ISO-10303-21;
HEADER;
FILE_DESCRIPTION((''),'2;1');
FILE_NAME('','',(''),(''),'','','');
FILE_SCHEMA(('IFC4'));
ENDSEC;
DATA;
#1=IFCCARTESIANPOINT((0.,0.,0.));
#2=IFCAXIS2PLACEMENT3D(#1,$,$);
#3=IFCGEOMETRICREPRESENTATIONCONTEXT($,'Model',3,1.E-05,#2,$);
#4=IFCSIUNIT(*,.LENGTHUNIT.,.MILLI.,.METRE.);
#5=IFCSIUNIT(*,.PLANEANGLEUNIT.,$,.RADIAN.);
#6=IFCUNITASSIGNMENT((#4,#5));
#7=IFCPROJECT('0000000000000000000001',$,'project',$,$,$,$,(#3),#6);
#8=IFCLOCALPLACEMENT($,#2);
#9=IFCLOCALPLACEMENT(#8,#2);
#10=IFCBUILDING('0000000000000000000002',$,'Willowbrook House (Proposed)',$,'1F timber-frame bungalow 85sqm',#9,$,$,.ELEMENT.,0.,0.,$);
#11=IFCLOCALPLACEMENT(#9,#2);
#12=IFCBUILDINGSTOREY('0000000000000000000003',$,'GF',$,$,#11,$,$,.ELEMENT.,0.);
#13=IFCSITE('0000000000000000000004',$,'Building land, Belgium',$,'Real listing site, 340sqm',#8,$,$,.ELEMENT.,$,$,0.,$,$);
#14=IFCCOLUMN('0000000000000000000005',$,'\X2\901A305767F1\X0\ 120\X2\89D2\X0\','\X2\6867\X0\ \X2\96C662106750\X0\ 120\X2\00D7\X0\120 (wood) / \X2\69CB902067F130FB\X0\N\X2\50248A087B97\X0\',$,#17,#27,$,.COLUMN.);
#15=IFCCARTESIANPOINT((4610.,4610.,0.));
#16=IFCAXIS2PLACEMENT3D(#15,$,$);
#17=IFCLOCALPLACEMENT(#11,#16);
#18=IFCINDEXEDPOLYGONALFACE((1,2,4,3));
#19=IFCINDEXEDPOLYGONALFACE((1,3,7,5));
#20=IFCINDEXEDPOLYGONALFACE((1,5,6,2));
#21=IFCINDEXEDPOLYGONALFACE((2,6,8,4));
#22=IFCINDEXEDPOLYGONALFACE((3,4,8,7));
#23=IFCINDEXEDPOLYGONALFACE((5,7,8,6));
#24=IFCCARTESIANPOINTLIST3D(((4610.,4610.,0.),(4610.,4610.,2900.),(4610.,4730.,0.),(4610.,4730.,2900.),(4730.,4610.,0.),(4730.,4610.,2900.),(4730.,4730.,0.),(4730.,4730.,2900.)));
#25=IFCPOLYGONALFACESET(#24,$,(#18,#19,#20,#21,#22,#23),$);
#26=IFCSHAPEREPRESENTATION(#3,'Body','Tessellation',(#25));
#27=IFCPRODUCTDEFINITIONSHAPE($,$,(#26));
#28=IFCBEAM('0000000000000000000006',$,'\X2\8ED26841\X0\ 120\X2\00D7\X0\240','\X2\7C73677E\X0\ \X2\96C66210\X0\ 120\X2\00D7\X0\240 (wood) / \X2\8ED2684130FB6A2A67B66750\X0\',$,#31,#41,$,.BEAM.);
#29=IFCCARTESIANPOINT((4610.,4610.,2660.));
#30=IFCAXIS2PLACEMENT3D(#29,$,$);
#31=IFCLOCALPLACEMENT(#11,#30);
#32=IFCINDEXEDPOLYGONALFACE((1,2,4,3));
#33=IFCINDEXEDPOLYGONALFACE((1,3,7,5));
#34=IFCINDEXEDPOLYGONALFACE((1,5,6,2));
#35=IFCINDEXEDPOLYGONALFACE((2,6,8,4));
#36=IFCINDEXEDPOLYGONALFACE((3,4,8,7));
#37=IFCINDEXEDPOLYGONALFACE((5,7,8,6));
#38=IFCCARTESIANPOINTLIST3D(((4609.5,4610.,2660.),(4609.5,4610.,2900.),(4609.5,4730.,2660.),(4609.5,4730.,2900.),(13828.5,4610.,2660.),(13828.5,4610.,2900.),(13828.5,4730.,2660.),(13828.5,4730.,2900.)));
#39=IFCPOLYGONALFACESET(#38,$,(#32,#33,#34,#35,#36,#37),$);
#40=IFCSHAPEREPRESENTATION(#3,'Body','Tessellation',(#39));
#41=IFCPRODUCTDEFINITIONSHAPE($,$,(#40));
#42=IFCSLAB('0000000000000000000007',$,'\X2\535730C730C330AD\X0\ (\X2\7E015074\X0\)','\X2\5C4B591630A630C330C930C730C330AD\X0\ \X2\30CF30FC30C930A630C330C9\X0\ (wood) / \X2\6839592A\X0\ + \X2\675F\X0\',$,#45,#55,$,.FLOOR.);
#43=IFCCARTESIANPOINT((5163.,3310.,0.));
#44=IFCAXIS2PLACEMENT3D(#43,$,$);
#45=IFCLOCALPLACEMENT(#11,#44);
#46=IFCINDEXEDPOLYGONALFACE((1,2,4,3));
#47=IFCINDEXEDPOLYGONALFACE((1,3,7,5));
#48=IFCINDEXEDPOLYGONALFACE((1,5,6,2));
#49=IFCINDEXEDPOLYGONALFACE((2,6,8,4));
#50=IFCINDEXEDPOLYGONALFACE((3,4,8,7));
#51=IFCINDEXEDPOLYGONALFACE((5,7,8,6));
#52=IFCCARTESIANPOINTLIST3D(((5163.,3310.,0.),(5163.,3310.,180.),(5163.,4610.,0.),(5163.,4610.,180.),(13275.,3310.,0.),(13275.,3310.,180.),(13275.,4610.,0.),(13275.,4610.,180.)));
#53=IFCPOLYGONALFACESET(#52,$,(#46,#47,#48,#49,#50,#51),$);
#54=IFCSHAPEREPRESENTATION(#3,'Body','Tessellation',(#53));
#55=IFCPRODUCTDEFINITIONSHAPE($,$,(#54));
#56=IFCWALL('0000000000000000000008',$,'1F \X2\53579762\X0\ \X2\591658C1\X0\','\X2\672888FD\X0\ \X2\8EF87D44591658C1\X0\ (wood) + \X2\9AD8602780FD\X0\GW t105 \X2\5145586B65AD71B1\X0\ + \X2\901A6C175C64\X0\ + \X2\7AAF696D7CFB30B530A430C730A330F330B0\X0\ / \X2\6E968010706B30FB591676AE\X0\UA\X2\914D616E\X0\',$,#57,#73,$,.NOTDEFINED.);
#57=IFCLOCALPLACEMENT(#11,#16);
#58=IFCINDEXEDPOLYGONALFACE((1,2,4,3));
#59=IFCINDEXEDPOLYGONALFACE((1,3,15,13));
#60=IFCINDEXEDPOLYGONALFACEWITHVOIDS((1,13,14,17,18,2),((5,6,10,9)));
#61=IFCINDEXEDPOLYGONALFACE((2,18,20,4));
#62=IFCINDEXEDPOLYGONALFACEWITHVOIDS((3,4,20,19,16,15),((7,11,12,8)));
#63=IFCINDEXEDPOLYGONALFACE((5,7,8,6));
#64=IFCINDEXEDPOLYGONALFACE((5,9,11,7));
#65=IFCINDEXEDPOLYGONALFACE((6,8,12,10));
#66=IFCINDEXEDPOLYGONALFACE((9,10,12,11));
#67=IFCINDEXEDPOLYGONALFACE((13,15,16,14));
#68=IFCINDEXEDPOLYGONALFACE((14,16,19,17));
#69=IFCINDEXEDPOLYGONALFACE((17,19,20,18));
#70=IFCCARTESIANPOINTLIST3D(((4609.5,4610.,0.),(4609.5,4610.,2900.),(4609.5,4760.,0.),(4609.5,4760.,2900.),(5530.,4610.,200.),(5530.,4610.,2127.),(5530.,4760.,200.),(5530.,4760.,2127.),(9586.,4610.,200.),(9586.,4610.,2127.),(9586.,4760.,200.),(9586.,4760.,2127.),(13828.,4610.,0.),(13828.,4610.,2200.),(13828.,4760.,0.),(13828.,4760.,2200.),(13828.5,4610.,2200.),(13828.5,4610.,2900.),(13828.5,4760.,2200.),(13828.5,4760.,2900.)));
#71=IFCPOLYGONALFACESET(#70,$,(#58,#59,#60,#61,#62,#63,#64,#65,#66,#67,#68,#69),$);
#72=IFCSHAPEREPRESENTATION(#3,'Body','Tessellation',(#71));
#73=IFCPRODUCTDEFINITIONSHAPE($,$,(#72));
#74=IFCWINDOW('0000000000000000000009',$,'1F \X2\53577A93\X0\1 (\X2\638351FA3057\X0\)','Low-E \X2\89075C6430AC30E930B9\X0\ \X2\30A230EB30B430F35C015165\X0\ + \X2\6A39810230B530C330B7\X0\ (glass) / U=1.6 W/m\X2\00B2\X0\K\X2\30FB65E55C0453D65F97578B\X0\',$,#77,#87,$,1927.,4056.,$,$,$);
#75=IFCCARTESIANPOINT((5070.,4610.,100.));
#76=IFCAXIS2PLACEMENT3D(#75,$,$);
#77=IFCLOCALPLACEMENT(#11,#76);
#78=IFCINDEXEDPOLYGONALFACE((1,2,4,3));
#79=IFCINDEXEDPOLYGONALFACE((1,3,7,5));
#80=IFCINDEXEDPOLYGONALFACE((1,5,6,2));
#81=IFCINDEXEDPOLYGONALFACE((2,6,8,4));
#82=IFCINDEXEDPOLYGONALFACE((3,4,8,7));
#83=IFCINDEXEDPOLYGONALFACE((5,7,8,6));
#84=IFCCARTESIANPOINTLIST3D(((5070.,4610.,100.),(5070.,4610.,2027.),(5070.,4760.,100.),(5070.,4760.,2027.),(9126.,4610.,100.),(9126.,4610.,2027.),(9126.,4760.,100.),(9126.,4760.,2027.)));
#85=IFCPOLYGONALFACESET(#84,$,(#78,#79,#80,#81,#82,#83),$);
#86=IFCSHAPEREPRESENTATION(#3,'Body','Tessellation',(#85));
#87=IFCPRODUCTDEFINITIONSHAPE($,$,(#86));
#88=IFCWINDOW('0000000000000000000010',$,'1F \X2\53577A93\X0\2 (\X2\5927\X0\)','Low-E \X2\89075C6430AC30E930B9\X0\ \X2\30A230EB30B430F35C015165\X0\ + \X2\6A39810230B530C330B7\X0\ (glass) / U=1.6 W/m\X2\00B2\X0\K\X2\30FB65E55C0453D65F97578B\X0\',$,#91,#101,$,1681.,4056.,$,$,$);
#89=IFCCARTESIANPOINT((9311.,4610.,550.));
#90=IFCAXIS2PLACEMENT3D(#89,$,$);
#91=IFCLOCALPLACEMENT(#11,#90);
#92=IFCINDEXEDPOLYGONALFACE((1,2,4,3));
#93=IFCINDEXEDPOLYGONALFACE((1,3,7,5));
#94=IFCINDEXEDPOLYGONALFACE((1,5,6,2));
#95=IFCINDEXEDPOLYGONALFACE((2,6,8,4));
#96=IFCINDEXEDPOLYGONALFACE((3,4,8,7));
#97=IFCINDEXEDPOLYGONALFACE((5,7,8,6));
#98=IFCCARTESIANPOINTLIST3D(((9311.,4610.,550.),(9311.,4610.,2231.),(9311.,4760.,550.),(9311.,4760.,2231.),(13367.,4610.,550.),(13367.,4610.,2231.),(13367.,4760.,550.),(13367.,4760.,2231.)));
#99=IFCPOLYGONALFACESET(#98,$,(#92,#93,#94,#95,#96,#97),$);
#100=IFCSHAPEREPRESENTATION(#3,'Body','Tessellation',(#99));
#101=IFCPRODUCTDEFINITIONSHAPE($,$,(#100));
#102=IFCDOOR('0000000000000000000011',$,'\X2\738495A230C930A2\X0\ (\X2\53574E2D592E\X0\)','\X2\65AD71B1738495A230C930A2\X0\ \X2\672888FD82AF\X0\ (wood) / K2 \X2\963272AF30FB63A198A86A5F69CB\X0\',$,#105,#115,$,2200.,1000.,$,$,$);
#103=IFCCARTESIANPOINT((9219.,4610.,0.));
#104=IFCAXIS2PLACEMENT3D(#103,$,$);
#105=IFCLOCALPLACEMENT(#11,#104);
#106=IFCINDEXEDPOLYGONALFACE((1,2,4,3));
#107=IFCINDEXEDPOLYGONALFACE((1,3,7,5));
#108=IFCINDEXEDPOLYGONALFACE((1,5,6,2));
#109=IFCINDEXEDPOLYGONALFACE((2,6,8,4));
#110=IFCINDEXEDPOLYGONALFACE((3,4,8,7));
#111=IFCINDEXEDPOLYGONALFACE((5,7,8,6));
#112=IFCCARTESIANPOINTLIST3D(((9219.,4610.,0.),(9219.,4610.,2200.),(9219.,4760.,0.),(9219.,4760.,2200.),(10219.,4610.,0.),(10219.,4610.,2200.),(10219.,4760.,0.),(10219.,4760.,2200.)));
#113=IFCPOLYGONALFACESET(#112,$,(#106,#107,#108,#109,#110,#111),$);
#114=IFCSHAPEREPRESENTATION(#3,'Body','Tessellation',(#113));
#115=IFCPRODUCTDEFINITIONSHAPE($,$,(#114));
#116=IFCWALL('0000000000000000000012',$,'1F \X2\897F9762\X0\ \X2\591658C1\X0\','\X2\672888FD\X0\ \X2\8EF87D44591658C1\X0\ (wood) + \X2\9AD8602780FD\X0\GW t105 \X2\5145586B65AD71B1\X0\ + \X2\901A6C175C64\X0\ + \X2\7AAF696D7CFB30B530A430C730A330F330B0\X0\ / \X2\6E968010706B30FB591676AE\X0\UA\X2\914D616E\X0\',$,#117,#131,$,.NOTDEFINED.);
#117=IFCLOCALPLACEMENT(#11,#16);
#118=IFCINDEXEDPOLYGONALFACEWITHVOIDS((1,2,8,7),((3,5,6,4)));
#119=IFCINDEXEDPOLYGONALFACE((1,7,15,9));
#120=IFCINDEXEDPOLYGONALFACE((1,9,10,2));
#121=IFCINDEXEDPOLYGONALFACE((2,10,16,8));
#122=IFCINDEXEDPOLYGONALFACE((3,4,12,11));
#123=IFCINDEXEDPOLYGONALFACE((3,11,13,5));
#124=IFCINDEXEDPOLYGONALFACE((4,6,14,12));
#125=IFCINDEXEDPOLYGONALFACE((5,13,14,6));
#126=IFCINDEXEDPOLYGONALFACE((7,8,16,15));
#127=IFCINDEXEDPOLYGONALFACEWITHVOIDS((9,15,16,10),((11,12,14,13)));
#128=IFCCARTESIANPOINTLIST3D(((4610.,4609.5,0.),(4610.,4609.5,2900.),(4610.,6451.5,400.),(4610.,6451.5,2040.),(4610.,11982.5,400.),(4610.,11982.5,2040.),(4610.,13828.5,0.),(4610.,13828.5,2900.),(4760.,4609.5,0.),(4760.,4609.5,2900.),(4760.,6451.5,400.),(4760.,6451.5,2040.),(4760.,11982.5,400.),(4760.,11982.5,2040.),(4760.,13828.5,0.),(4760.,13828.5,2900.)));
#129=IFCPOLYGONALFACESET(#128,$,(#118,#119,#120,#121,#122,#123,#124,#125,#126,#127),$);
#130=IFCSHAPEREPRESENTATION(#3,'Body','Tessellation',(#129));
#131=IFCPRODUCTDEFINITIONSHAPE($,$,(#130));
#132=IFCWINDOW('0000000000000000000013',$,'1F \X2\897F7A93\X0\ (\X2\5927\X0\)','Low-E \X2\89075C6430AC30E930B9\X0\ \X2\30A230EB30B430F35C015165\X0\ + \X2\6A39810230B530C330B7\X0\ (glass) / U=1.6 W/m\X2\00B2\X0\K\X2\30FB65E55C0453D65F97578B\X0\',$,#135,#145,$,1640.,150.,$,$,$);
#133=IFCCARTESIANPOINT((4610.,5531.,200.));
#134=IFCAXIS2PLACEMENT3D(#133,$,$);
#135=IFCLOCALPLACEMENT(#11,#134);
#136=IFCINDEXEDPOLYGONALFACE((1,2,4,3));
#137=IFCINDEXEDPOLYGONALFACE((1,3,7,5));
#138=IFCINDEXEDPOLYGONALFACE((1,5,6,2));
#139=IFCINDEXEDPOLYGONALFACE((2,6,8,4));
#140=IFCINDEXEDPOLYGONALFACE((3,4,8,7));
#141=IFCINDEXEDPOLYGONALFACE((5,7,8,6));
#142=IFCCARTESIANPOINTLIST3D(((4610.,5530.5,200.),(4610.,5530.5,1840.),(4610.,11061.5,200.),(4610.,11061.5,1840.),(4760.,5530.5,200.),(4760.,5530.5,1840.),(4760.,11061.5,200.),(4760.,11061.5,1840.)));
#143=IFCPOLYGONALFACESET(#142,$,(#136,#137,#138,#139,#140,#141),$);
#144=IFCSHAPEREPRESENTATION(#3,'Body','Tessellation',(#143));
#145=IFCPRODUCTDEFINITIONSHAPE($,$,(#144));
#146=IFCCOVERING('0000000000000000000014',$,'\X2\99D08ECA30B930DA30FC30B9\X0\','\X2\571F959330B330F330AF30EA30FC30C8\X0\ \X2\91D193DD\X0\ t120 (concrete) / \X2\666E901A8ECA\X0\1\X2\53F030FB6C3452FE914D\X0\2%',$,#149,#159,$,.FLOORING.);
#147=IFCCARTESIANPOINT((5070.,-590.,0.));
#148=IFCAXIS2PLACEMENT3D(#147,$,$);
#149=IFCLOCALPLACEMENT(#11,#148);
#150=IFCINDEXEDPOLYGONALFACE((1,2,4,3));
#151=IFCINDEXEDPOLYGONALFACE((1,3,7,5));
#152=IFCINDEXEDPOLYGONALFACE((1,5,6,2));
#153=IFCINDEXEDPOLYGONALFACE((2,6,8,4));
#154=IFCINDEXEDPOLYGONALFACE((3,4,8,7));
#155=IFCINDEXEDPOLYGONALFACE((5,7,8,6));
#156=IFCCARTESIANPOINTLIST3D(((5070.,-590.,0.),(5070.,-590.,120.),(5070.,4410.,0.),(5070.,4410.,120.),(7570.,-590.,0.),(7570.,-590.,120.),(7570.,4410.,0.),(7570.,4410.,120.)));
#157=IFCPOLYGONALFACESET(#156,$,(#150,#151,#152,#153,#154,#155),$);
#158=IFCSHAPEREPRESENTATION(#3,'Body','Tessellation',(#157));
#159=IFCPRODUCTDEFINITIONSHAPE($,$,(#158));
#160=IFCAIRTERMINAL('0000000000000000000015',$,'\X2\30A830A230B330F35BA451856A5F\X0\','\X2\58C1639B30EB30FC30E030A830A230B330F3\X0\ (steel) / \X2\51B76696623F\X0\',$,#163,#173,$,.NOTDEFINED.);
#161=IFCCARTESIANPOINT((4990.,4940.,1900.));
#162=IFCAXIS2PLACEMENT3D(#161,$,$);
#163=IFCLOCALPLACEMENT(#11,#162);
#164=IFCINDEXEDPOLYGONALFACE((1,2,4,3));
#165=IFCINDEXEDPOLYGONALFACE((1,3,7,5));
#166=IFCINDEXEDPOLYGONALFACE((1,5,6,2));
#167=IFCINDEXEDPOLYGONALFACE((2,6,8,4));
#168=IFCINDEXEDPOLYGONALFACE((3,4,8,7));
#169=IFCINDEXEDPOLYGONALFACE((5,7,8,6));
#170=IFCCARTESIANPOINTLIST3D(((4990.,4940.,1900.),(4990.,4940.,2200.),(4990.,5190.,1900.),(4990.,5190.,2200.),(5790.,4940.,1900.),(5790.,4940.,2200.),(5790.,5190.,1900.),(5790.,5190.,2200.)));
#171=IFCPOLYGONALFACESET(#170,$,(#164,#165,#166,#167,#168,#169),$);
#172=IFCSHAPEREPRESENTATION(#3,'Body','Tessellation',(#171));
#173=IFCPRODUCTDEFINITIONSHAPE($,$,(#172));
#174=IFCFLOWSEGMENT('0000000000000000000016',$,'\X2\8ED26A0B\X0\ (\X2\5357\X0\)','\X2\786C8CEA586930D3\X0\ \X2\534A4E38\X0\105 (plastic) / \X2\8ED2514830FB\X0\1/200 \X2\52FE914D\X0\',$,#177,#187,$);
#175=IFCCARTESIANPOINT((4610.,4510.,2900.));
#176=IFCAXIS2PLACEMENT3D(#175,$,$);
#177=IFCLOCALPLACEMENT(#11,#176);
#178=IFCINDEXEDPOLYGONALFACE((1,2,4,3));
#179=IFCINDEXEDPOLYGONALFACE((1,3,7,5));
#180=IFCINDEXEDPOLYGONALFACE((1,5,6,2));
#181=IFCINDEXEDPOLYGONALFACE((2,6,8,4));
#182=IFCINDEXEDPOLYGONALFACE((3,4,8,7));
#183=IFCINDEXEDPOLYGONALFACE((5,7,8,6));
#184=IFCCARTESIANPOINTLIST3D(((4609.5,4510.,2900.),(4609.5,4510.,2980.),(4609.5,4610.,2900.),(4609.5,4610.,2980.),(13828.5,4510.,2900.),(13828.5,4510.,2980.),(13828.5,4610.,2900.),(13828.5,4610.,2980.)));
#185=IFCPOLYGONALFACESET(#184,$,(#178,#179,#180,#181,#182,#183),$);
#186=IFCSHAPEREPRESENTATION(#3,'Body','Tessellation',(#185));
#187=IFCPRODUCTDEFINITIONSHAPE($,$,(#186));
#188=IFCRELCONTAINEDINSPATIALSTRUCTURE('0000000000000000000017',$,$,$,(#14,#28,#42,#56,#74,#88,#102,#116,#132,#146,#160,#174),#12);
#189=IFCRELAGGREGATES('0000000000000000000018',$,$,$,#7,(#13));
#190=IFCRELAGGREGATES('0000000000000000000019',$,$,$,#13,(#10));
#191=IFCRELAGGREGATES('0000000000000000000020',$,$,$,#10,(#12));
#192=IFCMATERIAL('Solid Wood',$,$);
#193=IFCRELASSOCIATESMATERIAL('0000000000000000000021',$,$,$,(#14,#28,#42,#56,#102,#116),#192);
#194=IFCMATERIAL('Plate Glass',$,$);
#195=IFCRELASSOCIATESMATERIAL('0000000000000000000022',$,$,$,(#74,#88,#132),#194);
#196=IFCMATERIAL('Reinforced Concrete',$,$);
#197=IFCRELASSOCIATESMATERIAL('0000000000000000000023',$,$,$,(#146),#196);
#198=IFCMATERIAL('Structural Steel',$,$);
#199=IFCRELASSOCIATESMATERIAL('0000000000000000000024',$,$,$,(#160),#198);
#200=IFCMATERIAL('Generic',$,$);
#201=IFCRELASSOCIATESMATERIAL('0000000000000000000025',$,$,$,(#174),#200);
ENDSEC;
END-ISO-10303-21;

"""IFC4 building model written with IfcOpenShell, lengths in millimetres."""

from ifc_helpers import new_model, si_unit, frame, frame_2d, origin, place, context, project, spatial, rectangle, extrude, material, element, fill, save


model = new_model("IFC4")

# Units and contexts
model_context = context("Model", 3, precision=1e-05, world=origin())
ifc_project = project(units=[si_unit("LENGTHUNIT", "METRE", prefix="MILLI"), si_unit("PLANEANGLEUNIT", "RADIAN")], contexts=[model_context])

# Site, building, storey
site_placement = place(None, origin())
site = spatial("IfcSite", under=ifc_project, at=site_placement, Name="Building land, Belgium", ObjectType="Real listing site, 340sqm", CompositionType="ELEMENT", RefElevation=0.0)
building_placement = place(site_placement, origin())
building = spatial("IfcBuilding", under=site, at=building_placement, Name="Willowbrook House (Proposed)", ObjectType="1F timber-frame bungalow 85sqm", CompositionType="ELEMENT", ElevationOfRefHeight=0.0, ElevationOfTerrain=0.0)
storey_placement = place(building_placement, origin())
storey = spatial("IfcBuildingStorey", under=building, at=storey_placement, Name="GF", CompositionType="ELEMENT", Elevation=0.0)

# Column
ifc_material_1 = material(Name="Solid Wood")
column_1_placement = place(storey_placement, frame((4610.0, 4610.0, 0.0)))
element("IfcColumn", 1, at=column_1_placement, inside=storey, material=ifc_material_1, Name="通し柱 120角", Description="桧 集成材 120×120 (wood) / 構造柱・N値計算", PredefinedType="COLUMN", context=model_context, shape_type="SweptSolid", body=[
    extrude(rectangle(XDim=120.0, YDim=120.0, at=frame_2d((60.0, 60.0))), frame((4610.0, 4610.0, 0.0)), (0.0, 0.0, 1.0), 2900.0),
])

# Beam
beam_1_placement = place(storey_placement, frame((4610.0, 4610.0, 2660.0)))
element("IfcBeam", 2, at=beam_1_placement, inside=storey, material=ifc_material_1, Name="軒桁 120×240", Description="米松 集成 120×240 (wood) / 軒桁・横架材", PredefinedType="BEAM", context=model_context, shape_type="SweptSolid", body=[
    extrude(rectangle(XDim=9219.0, YDim=120.0, at=frame_2d((4609.0, 60.0))), frame((4610.0, 4610.0, 2660.0)), (0.0, 0.0, 1.0), 240.0),
])

# Slab
ifc_material_2 = material(Name="Reinforced Concrete")
slab_1_placement = place(storey_placement, frame((5163.0, 3310.0, 0.0)))
element("IfcSlab", 3, at=slab_1_placement, inside=storey, material=ifc_material_1, Name="南デッキ (縁側)", Description="屋外ウッドデッキ ハードウッド (wood) / 根太 + 束", PredefinedType="FLOOR", context=model_context, shape_type="SweptSolid", body=[
    extrude(rectangle(XDim=8112.0, YDim=1300.0, at=frame_2d((4056.0, 650.0))), frame((5163.0, 3310.0, 0.0)), (0.0, 0.0, 1.0), 180.0),
])

# Wall, openings, windows, door
wall_1_placement = place(storey_placement, frame((4610.0, 4610.0, 0.0)))
wall_1 = element("IfcWall", 4, at=wall_1_placement, inside=storey, material=ifc_material_1, Name="1F 南面 外壁", Description="木製 軸組外壁 (wood) + 高性能GW t105 充填断熱 + 通気層 + 窯業系サイディング / 準耐火・外皮UA配慮", PredefinedType="NOTDEFINED", context=model_context, shape_type="SweptSolid", body=[
    extrude(rectangle(XDim=9219.0, YDim=150.0, at=frame_2d((4609.0, 75.0))), frame((4610.0, 4610.0, 0.0)), (0.0, 0.0, 1.0), 2900.0),
])
opening_1_placement = place(storey_placement, frame((5070.0, 4610.0, 100.0)))
opening_1 = element("IfcOpeningElement", 5, at=opening_1_placement, cuts=wall_1, PredefinedType="NOTDEFINED", context=model_context, shape_type="SweptSolid", body=[
    extrude(rectangle(XDim=4056.0, YDim=150.0, at=frame_2d((2028.0, 75.0))), frame((5070.0, 4610.0, 100.0)), (0.0, 0.0, 1.0), 1927.0),
])
opening_2_placement = place(storey_placement, frame((9311.0, 4610.0, 550.0)))
opening_2 = element("IfcOpeningElement", 6, at=opening_2_placement, cuts=wall_1, PredefinedType="NOTDEFINED", context=model_context, shape_type="SweptSolid", body=[
    extrude(rectangle(XDim=4056.0, YDim=150.0, at=frame_2d((2028.0, 75.0))), frame((9311.0, 4610.0, 550.0)), (0.0, 0.0, 1.0), 1681.0),
])
opening_3_placement = place(storey_placement, frame((9219.0, 4610.0, 0.0)))
opening_3 = element("IfcOpeningElement", 7, at=opening_3_placement, cuts=wall_1, PredefinedType="NOTDEFINED", context=model_context, shape_type="SweptSolid", body=[
    extrude(rectangle(XDim=1000.0, YDim=150.0, at=frame_2d((500.0, 75.0))), frame((9219.0, 4610.0, 0.0)), (0.0, 0.0, 1.0), 2200.0),
])
ifc_material_3 = material(Name="Plate Glass")
window_1_placement = place(storey_placement, frame((5070.0, 4610.0, 100.0)))
window_1 = element("IfcWindow", 8, at=window_1_placement, inside=storey, material=ifc_material_3, Name="1F 南窓1 (掃出し)", Description="Low-E 複層ガラス アルゴン封入 + 樹脂サッシ (glass) / U=1.6 W/m²K・日射取得型", OverallHeight=1927.0, OverallWidth=4056.0, context=model_context, shape_type="SweptSolid", body=[
    extrude(rectangle(XDim=4056.0, YDim=150.0, at=frame_2d((2028.0, 75.0))), frame((5070.0, 4610.0, 100.0)), (0.0, 0.0, 1.0), 1927.0),
])
fill(opening_1, window_1)
window_2_placement = place(storey_placement, frame((9311.0, 4610.0, 550.0)))
window_2 = element("IfcWindow", 9, at=window_2_placement, inside=storey, material=ifc_material_3, Name="1F 南窓2 (大)", Description="Low-E 複層ガラス アルゴン封入 + 樹脂サッシ (glass) / U=1.6 W/m²K・日射取得型", OverallHeight=1681.0, OverallWidth=4056.0, context=model_context, shape_type="SweptSolid", body=[
    extrude(rectangle(XDim=4056.0, YDim=150.0, at=frame_2d((2028.0, 75.0))), frame((9311.0, 4610.0, 550.0)), (0.0, 0.0, 1.0), 1681.0),
])
fill(opening_2, window_2)
door_placement = place(storey_placement, frame((9219.0, 4610.0, 0.0)))
door = element("IfcDoor", 10, at=door_placement, inside=storey, material=ifc_material_1, Name="玄関ドア (南中央)", Description="断熱玄関ドア 木製芯 (wood) / K2 防犯・採風機構", OverallHeight=2200.0, OverallWidth=1000.0, context=model_context, shape_type="SweptSolid", body=[
    extrude(rectangle(XDim=1000.0, YDim=150.0, at=frame_2d((500.0, 75.0))), frame((9219.0, 4610.0, 0.0)), (0.0, 0.0, 1.0), 2200.0),
])
fill(opening_3, door)

# Wall, opening, window
wall_2_placement = place(storey_placement, frame((4610.0, 4610.0, 0.0)))
wall_2 = element("IfcWall", 11, at=wall_2_placement, inside=storey, material=ifc_material_1, Name="1F 西面 外壁", Description="木製 軸組外壁 (wood) + 高性能GW t105 充填断熱 + 通気層 + 窯業系サイディング / 準耐火・外皮UA配慮", PredefinedType="NOTDEFINED", context=model_context, shape_type="SweptSolid", body=[
    extrude(rectangle(XDim=150.0, YDim=9219.0, at=frame_2d((75.0, 4609.0))), frame((4610.0, 4610.0, 0.0)), (0.0, 0.0, 1.0), 2900.0),
])
opening_4_placement = place(storey_placement, frame((4610.0, 5531.0, 200.0)))
opening_4 = element("IfcOpeningElement", 12, at=opening_4_placement, cuts=wall_2, PredefinedType="NOTDEFINED", context=model_context, shape_type="SweptSolid", body=[
    extrude(rectangle(XDim=150.0, YDim=5531.0, at=frame_2d((75.0, 2765.0))), frame((4610.0, 5531.0, 200.0)), (0.0, 0.0, 1.0), 1640.0),
])
window_3_placement = place(storey_placement, frame((4610.0, 5531.0, 200.0)))
window_3 = element("IfcWindow", 13, at=window_3_placement, inside=storey, material=ifc_material_3, Name="1F 西窓 (大)", Description="Low-E 複層ガラス アルゴン封入 + 樹脂サッシ (glass) / U=1.6 W/m²K・日射取得型", OverallHeight=1640.0, OverallWidth=150.0, context=model_context, shape_type="SweptSolid", body=[
    extrude(rectangle(XDim=150.0, YDim=5531.0, at=frame_2d((75.0, 2765.0))), frame((4610.0, 5531.0, 200.0)), (0.0, 0.0, 1.0), 1640.0),
])
fill(opening_4, window_3)

# Shared definitions
ifc_material_4 = material(Name="Structural Steel")

# Covering
ifc_material_5 = material(Name="Generic")
covering_1_placement = place(storey_placement, frame((5070.0, -590.0, 0.0)))
element("IfcCovering", 14, at=covering_1_placement, inside=storey, material=ifc_material_2, Name="駐車スペース", Description="土間コンクリート 金鏝 t120 (concrete) / 普通車1台・水勾配2%", PredefinedType="FLOORING", context=model_context, shape_type="SweptSolid", body=[
    extrude(rectangle(XDim=2500.0, YDim=5000.0, at=frame_2d((1250.0, 2500.0))), frame((5070.0, -590.0, 0.0)), (0.0, 0.0, 1.0), 120.0),
])

# Air terminal
air_terminal_placement = place(storey_placement, frame((4990.0, 4940.0, 1900.0)))
element("IfcAirTerminal", 15, at=air_terminal_placement, inside=storey, material=ifc_material_4, Name="エアコン室内機", Description="壁掛ルームエアコン (steel) / 冷暖房", PredefinedType="NOTDEFINED", context=model_context, shape_type="SweptSolid", body=[
    extrude(rectangle(XDim=800.0, YDim=250.0, at=frame_2d((400.0, 125.0))), frame((4990.0, 4940.0, 1900.0)), (0.0, 0.0, 1.0), 300.0),
])

# Flow segment
flow_segment_1_placement = place(storey_placement, frame((4610.0, 4510.0, 2900.0)))
element("IfcFlowSegment", 16, at=flow_segment_1_placement, inside=storey, material=ifc_material_5, Name="軒樋 (南)", Description="硬質塩ビ 半丸105 (plastic) / 軒先・1/200 勾配", context=model_context, shape_type="SweptSolid", body=[
    extrude(rectangle(XDim=9219.0, YDim=100.0, at=frame_2d((4609.0, 50.0))), frame((4610.0, 4510.0, 2900.0)), (0.0, 0.0, 1.0), 80.0),
])

save(model, "model.ifc")
